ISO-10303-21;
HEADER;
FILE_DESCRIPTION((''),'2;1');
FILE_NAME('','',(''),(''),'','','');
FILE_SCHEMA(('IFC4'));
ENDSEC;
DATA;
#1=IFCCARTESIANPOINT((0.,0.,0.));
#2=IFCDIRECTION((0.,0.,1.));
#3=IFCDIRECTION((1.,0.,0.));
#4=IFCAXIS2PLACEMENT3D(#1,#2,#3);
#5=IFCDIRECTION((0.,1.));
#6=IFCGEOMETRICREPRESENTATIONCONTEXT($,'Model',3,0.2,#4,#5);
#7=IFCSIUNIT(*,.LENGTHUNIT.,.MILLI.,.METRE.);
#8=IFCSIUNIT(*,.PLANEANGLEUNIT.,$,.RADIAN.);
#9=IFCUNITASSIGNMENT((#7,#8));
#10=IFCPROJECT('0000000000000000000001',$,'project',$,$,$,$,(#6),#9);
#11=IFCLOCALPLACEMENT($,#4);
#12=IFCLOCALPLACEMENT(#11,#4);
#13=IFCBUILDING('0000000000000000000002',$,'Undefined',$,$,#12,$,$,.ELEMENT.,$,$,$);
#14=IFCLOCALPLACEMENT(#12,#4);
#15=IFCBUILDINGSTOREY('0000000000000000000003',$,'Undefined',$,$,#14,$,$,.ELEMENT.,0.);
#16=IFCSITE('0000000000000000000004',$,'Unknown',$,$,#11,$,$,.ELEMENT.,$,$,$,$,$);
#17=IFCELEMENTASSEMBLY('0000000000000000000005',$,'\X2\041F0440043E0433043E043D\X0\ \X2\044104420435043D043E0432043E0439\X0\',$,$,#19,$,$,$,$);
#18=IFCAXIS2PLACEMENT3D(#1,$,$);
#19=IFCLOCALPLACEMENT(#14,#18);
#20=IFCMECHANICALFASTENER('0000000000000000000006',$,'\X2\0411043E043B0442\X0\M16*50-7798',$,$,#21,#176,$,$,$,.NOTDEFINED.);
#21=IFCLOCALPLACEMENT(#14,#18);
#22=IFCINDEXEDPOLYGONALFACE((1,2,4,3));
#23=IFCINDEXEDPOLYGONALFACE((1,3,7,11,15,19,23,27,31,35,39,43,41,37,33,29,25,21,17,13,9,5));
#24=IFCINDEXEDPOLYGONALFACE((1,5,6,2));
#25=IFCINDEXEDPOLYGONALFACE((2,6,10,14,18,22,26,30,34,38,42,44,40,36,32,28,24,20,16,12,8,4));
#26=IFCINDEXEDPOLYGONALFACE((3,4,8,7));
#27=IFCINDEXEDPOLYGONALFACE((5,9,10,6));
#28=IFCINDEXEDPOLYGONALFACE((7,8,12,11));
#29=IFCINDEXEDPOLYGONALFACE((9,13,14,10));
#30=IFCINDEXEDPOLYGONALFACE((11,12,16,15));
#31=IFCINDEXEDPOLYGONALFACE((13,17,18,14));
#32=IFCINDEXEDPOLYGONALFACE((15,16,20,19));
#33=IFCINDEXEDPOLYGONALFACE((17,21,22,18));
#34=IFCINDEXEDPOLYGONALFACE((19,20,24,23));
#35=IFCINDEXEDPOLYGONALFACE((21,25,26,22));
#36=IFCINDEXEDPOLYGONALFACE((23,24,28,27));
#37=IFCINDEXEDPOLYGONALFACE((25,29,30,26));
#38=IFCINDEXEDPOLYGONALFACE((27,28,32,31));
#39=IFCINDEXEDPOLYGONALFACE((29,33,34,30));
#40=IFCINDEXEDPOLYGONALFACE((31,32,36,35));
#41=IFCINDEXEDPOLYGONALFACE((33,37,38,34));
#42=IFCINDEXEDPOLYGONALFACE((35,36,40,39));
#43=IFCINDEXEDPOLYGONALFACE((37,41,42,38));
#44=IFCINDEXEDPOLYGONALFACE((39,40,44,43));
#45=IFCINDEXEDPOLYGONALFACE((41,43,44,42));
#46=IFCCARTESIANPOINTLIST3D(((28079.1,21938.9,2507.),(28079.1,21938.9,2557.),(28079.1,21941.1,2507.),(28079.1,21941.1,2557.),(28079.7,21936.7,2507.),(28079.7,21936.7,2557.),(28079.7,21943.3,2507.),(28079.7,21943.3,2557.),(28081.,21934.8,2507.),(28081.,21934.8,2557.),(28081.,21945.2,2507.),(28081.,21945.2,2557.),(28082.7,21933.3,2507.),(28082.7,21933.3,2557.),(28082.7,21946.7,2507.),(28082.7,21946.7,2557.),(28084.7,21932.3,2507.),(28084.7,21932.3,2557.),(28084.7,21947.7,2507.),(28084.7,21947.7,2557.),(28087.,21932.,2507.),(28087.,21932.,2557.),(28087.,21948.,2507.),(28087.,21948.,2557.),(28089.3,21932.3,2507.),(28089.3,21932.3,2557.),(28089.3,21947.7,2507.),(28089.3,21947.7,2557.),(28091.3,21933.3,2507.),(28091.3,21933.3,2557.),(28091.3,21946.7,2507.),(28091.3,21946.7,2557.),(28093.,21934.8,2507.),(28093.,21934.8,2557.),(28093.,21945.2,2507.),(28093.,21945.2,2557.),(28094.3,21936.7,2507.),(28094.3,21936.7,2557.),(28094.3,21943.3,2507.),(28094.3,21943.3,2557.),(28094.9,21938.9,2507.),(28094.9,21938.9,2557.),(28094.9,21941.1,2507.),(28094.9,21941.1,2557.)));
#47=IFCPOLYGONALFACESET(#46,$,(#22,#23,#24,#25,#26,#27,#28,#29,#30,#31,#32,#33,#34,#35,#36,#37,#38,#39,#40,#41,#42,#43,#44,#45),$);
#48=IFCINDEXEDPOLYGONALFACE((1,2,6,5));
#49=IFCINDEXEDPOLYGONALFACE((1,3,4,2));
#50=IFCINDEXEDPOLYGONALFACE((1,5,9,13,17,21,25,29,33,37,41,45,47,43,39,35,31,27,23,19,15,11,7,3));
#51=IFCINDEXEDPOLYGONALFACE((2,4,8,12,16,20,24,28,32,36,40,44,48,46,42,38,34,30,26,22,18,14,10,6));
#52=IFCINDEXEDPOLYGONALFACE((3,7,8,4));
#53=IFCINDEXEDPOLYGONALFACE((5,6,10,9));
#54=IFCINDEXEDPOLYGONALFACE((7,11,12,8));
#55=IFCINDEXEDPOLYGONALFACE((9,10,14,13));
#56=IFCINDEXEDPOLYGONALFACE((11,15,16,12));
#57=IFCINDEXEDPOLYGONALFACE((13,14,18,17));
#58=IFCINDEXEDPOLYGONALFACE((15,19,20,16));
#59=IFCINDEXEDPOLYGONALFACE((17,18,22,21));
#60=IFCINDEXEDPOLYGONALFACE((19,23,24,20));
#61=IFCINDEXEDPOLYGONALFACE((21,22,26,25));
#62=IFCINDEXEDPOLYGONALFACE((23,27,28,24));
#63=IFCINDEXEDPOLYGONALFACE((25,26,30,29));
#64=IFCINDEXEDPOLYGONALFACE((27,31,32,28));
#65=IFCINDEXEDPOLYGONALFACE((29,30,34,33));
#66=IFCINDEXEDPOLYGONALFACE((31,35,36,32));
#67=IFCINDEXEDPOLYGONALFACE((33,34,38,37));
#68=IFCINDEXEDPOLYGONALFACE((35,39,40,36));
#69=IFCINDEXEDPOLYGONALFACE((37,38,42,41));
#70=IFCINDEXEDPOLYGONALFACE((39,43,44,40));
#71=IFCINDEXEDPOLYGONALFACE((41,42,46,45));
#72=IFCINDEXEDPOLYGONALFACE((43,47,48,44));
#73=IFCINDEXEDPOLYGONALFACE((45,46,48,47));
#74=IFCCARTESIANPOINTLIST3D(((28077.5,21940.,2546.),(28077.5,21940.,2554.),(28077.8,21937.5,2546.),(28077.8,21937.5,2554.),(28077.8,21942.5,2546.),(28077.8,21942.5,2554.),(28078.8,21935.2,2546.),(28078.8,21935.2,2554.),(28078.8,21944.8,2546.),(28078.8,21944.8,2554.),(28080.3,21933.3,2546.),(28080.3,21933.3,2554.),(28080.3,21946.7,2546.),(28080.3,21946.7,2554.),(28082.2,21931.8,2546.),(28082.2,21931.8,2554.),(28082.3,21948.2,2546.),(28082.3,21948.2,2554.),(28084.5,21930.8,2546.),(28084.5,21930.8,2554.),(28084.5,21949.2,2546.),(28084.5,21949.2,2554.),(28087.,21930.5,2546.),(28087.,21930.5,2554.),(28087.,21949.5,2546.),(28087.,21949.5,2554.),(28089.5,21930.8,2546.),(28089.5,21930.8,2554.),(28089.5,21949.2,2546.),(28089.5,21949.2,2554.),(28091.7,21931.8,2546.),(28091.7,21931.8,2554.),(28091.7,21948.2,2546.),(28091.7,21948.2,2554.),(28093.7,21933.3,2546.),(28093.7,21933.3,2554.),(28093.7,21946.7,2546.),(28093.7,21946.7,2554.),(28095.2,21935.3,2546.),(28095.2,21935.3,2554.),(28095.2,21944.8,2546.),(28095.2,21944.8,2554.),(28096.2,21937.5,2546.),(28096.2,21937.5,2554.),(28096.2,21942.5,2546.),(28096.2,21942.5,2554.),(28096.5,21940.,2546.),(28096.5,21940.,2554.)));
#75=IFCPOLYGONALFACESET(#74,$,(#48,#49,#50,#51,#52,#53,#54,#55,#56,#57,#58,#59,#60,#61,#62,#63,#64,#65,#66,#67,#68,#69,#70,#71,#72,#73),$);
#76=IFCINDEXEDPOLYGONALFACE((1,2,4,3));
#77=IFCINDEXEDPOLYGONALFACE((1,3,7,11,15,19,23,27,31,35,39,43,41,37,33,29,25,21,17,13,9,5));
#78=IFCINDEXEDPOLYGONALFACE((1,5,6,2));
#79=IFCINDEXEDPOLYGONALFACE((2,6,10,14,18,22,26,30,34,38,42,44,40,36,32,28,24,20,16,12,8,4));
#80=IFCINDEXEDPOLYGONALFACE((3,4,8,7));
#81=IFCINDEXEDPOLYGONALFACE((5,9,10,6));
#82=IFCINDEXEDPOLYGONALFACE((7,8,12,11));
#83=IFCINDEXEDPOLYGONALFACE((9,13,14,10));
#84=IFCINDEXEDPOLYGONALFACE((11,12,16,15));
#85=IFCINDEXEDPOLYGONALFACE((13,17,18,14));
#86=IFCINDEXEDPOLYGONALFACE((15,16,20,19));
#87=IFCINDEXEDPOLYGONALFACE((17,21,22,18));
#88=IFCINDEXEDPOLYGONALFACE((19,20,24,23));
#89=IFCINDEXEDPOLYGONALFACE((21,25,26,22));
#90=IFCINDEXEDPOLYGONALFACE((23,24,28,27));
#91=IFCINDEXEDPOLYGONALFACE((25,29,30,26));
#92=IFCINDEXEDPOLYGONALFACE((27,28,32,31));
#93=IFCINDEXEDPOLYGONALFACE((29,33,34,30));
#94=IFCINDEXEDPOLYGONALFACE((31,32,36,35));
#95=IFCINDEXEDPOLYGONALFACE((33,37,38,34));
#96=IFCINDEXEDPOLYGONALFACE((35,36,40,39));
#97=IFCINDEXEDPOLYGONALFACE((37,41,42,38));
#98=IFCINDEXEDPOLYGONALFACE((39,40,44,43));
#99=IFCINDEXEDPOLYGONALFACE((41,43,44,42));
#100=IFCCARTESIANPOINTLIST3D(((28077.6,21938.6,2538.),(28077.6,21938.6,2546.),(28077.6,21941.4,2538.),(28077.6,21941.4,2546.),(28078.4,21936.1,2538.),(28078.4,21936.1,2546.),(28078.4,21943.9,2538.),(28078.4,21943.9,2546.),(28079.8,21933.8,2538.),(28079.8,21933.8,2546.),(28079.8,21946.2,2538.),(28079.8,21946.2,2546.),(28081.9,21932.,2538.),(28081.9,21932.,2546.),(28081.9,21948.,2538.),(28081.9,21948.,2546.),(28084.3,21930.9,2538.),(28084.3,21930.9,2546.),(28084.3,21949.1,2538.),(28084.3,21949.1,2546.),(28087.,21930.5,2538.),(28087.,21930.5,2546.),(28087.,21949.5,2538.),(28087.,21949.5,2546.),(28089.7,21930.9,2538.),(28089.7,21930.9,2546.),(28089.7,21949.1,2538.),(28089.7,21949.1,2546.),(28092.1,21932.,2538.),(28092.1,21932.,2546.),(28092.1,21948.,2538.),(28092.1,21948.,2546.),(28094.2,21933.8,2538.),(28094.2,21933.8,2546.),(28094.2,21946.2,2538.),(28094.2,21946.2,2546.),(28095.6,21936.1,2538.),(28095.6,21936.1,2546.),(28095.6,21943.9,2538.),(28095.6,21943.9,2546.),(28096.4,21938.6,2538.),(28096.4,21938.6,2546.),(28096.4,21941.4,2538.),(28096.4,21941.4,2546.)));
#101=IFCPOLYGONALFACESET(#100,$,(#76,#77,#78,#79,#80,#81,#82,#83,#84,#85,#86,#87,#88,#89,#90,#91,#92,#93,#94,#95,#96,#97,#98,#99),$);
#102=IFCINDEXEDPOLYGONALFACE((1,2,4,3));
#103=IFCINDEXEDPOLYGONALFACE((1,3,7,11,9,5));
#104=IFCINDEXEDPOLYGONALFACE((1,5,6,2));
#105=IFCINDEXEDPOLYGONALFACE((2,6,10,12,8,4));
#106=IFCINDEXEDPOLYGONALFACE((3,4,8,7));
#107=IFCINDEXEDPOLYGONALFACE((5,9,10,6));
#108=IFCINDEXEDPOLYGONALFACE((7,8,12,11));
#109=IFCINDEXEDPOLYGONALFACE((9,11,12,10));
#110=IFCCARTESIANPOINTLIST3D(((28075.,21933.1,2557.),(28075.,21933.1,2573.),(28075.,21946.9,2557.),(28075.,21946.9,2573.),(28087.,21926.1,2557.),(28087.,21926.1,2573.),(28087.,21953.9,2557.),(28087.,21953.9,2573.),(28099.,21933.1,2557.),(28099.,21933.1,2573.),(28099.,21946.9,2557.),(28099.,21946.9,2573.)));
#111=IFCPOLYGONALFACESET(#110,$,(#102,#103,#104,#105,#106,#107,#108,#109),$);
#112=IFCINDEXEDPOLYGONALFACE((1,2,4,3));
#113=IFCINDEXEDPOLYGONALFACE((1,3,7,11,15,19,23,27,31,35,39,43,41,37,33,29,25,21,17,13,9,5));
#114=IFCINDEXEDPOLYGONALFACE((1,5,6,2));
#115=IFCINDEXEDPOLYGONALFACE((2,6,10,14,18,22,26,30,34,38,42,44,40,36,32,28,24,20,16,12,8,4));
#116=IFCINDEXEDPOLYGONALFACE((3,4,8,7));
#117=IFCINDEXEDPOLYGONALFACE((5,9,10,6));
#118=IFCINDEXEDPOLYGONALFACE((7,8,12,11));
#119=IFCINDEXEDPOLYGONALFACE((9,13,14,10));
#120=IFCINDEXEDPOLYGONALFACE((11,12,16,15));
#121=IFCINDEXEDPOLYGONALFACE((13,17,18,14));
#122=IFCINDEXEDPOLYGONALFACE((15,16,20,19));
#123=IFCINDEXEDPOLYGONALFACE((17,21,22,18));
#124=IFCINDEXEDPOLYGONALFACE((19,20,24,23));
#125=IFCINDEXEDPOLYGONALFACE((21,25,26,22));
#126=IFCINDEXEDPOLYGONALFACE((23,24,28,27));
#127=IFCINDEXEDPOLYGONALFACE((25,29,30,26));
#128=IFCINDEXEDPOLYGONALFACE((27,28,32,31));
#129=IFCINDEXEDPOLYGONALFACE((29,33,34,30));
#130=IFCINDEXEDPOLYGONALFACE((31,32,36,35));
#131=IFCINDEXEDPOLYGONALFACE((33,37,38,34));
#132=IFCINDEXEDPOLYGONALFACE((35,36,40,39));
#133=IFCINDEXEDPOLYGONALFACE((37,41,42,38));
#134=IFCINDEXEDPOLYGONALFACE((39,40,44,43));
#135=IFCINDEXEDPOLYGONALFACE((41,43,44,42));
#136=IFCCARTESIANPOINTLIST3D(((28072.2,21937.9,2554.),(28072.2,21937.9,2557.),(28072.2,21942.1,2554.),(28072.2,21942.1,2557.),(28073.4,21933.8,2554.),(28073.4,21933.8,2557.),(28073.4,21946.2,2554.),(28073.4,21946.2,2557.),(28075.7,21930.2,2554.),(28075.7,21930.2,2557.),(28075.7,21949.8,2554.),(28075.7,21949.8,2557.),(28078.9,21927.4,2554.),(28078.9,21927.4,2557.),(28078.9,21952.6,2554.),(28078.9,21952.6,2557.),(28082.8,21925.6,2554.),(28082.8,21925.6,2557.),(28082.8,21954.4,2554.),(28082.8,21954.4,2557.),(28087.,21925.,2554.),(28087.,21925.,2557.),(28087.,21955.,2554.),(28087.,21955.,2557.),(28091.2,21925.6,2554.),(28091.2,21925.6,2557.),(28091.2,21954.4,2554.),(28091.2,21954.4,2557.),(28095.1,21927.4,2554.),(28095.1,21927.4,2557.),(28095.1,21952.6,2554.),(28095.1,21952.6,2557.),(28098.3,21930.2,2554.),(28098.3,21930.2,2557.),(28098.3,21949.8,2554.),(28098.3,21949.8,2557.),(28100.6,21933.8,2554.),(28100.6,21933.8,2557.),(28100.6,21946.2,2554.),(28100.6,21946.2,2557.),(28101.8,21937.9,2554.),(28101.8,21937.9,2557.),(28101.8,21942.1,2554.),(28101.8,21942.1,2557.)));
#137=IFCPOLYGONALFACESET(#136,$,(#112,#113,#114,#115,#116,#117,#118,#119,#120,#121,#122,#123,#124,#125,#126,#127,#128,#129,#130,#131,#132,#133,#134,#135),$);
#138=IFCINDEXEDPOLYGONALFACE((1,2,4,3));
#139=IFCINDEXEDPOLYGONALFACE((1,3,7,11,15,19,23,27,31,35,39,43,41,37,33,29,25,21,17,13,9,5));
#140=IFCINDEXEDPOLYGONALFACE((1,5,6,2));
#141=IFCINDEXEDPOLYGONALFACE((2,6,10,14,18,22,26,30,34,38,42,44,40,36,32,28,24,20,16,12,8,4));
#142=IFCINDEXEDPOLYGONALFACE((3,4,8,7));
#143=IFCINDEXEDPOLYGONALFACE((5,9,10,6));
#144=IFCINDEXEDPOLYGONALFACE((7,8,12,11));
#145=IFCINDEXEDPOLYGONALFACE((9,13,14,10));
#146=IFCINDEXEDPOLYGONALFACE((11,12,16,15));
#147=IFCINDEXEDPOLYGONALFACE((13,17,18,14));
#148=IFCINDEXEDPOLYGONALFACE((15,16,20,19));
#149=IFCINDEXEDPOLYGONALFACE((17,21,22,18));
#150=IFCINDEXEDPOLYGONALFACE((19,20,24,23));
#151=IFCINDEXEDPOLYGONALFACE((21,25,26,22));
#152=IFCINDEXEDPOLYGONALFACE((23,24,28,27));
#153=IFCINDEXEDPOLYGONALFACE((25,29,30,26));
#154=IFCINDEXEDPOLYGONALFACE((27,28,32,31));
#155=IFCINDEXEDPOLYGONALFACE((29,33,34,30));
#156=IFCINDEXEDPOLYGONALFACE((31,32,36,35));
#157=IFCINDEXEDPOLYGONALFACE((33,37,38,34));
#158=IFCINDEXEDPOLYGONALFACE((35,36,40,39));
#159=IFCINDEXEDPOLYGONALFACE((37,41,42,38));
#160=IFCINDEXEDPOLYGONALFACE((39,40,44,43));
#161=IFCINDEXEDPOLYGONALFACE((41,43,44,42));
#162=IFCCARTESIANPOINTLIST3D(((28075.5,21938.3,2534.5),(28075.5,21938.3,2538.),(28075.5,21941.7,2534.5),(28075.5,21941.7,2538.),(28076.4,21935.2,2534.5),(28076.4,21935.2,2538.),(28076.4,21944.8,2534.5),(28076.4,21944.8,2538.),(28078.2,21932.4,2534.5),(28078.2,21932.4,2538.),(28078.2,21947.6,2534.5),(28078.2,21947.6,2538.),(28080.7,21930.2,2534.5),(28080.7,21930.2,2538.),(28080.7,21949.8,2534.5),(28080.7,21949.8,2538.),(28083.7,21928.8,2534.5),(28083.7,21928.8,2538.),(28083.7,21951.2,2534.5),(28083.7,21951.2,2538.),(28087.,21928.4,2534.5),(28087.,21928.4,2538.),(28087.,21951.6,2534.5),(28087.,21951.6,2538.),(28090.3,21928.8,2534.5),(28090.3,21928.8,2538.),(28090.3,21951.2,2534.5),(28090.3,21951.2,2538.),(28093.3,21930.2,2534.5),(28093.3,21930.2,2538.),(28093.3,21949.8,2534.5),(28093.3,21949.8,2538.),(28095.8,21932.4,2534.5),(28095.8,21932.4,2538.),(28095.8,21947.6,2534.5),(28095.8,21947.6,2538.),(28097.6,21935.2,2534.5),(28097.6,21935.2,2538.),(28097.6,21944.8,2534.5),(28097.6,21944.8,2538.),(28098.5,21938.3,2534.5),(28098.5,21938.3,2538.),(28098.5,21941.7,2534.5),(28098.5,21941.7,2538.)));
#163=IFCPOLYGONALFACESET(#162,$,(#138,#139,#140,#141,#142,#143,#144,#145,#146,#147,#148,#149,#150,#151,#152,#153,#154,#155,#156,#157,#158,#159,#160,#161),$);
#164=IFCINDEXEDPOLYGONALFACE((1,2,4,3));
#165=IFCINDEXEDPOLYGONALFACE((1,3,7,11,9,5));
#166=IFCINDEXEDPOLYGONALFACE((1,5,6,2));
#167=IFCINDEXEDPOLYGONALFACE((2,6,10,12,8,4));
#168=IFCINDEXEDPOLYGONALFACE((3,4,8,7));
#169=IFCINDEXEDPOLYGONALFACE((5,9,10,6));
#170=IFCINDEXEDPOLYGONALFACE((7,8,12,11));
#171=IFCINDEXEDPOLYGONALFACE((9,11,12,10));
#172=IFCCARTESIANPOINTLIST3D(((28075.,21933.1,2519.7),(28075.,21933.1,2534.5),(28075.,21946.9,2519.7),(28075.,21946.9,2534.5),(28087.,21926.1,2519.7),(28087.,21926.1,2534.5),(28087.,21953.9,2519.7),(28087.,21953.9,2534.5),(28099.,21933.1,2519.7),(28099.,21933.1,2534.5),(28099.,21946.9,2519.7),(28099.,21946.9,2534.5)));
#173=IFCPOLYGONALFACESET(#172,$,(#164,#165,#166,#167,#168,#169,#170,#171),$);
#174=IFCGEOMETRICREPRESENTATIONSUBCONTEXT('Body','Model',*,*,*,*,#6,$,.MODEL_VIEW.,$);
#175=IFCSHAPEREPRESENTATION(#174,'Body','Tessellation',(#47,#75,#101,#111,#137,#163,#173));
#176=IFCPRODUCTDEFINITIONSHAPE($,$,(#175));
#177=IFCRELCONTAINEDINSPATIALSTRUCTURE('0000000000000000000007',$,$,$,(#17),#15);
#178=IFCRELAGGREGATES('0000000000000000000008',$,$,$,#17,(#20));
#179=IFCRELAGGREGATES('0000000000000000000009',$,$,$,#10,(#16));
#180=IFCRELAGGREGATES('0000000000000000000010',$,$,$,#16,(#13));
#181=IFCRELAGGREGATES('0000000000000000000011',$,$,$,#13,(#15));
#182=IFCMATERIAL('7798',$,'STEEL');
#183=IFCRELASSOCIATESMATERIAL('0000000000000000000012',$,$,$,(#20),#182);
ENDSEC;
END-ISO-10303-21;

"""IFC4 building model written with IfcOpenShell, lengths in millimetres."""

from ifc_helpers import new_model, si_unit, direction, frame, origin_with_axes, place, context, subcontext, project, spatial, line, arc, indexed_curve, outline, extrude, source, transform, mapped, material, element, aggregate, save


model = new_model("IFC4")

# Units and contexts
model_context = context("Model", 3, precision=0.2, world=origin_with_axes(), true_north=direction((0.0, 1.0)))
body_context = subcontext(model_context, "Body", "Model", "MODEL_VIEW")
ifc_project = project(units=[si_unit("LENGTHUNIT", "METRE", prefix="MILLI"), si_unit("PLANEANGLEUNIT", "RADIAN")], contexts=[model_context])

# Site, building, storey
site_placement = place(None, origin_with_axes())
site = spatial("IfcSite", under=ifc_project, at=site_placement, Name="Unknown", CompositionType="ELEMENT")
building_placement = place(site_placement, origin_with_axes())
building = spatial("IfcBuilding", under=site, at=building_placement, Name="Undefined", CompositionType="ELEMENT")
storey_placement = place(building_placement, origin_with_axes())
storey = spatial("IfcBuildingStorey", under=building, at=storey_placement, Name="Undefined", CompositionType="ELEMENT", Elevation=0.0)

# Element assembly, mechanical fastener
assembly_1_placement = place(storey_placement, frame((34000.0, 21950.0, 2550.0), z_axis=(0.0, 0.0, -1.0), x_axis=(-1.0, 0.0, 0.0)))
assembly_1 = element("IfcElementAssembly", 1, at=assembly_1_placement, inside=storey, Name="Прогон стеновой")
ifc_material_1 = material(Name="7798", Category="STEEL")
shared_shape_1 = source(origin_with_axes(), body_context, "Body", "SweptSolid", [
    extrude(outline(indexed_curve([(8.0, 0.0), (0.0, 8.0), (-8.0, 0.0), (0.0, -8.0)], segments=[arc(1, 2, 3), arc(3, 4, 1)])), frame((0.0, 0.0, 7.0), z_axis=(0.0, 0.0, -1.0), x_axis=(0.0, 1.0, 0.0)), (0.0, 0.0, 1.0), 50.0),
    extrude(outline(indexed_curve([(0.0, 9.5), (6.7, 6.7), (9.5, 0.0), (6.7, -6.7), (0.0, -9.5), (-0.9, -9.5), (-9.5, 0.0), (-6.7, 6.7)], segments=[arc(1, 2, 3), arc(3, 4, 5), arc(5, 6, 7), arc(7, 8, 1)])), frame((0.0, 0.0, 4.0), z_axis=(0.0, 0.0, -1.0), x_axis=(0.0, 1.0, 0.0)), (0.0, 0.0, 1.0), 8.0),
    extrude(outline(indexed_curve([(9.5, 0.0), (0.0, 9.5), (-9.5, 0.0), (0.0, -9.5)], segments=[arc(1, 2, 3), arc(3, 4, 1)])), frame((0.0, 0.0, -4.0), z_axis=(0.0, 0.0, -1.0), x_axis=(0.0, 1.0, 0.0)), (0.0, 0.0, 1.0), 8.0),
    extrude(outline(indexed_curve([(13.9, 0.0), (6.9, 12.0), (-6.9, 12.0), (-13.9, 0.0), (-6.9, -12.0), (6.9, -12.0)], segments=[line(1, 2, 3, 4, 5, 6, 1)])), frame((0.0, 0.0, 23.0), z_axis=(0.0, 0.0, -1.0), x_axis=(0.0, 1.0, 0.0)), (0.0, 0.0, 1.0), 16.0),
    extrude(outline(indexed_curve([(15.0, 0.0), (0.0, 15.0), (-15.0, 0.0), (0.0, -15.0)], segments=[arc(1, 2, 3), arc(3, 4, 1)])), frame((0.0, 0.0, 7.0), z_axis=(0.0, 0.0, -1.0), x_axis=(0.0, 1.0, 0.0)), (0.0, 0.0, 1.0), 3.0),
    extrude(outline(indexed_curve([(11.7, 0.0), (0.0, 11.7), (-11.7, 0.0), (0.0, -11.7)], segments=[arc(1, 2, 3), arc(3, 4, 1)])), frame((0.0, 0.0, -12.0), z_axis=(0.0, 0.0, -1.0), x_axis=(0.0, 1.0, 0.0)), (0.0, 0.0, 1.0), 3.5),
    extrude(outline(indexed_curve([(13.9, 0.0), (6.9, 12.0), (-6.9, 12.0), (-13.9, 0.0), (-6.9, -12.0), (6.9, -12.0)], segments=[line(1, 2, 3, 4, 5, 6, 1)])), frame((0.0, 0.0, -15.5), z_axis=(0.0, 0.0, -1.0), x_axis=(0.0, 1.0, 0.0)), (0.0, 0.0, 1.0), 14.8),
])
mechanical_fastener_1_placement = place(assembly_1_placement, frame((5913.0, -10.0, 0.0), z_axis=(0.0, 0.0, -1.0), x_axis=(-1.0, 0.0, 0.0)))
mechanical_fastener_1 = element("IfcMechanicalFastener", 2, at=mechanical_fastener_1_placement, material=ifc_material_1, Name="БолтM16*50-7798", PredefinedType="NOTDEFINED", context=body_context, shape_type="MappedRepresentation", body=[
    mapped(shared_shape_1, transform((0.0, 0.0, 0.0))),
])
aggregate(assembly_1, [mechanical_fastener_1])

save(model, "model.ifc")
